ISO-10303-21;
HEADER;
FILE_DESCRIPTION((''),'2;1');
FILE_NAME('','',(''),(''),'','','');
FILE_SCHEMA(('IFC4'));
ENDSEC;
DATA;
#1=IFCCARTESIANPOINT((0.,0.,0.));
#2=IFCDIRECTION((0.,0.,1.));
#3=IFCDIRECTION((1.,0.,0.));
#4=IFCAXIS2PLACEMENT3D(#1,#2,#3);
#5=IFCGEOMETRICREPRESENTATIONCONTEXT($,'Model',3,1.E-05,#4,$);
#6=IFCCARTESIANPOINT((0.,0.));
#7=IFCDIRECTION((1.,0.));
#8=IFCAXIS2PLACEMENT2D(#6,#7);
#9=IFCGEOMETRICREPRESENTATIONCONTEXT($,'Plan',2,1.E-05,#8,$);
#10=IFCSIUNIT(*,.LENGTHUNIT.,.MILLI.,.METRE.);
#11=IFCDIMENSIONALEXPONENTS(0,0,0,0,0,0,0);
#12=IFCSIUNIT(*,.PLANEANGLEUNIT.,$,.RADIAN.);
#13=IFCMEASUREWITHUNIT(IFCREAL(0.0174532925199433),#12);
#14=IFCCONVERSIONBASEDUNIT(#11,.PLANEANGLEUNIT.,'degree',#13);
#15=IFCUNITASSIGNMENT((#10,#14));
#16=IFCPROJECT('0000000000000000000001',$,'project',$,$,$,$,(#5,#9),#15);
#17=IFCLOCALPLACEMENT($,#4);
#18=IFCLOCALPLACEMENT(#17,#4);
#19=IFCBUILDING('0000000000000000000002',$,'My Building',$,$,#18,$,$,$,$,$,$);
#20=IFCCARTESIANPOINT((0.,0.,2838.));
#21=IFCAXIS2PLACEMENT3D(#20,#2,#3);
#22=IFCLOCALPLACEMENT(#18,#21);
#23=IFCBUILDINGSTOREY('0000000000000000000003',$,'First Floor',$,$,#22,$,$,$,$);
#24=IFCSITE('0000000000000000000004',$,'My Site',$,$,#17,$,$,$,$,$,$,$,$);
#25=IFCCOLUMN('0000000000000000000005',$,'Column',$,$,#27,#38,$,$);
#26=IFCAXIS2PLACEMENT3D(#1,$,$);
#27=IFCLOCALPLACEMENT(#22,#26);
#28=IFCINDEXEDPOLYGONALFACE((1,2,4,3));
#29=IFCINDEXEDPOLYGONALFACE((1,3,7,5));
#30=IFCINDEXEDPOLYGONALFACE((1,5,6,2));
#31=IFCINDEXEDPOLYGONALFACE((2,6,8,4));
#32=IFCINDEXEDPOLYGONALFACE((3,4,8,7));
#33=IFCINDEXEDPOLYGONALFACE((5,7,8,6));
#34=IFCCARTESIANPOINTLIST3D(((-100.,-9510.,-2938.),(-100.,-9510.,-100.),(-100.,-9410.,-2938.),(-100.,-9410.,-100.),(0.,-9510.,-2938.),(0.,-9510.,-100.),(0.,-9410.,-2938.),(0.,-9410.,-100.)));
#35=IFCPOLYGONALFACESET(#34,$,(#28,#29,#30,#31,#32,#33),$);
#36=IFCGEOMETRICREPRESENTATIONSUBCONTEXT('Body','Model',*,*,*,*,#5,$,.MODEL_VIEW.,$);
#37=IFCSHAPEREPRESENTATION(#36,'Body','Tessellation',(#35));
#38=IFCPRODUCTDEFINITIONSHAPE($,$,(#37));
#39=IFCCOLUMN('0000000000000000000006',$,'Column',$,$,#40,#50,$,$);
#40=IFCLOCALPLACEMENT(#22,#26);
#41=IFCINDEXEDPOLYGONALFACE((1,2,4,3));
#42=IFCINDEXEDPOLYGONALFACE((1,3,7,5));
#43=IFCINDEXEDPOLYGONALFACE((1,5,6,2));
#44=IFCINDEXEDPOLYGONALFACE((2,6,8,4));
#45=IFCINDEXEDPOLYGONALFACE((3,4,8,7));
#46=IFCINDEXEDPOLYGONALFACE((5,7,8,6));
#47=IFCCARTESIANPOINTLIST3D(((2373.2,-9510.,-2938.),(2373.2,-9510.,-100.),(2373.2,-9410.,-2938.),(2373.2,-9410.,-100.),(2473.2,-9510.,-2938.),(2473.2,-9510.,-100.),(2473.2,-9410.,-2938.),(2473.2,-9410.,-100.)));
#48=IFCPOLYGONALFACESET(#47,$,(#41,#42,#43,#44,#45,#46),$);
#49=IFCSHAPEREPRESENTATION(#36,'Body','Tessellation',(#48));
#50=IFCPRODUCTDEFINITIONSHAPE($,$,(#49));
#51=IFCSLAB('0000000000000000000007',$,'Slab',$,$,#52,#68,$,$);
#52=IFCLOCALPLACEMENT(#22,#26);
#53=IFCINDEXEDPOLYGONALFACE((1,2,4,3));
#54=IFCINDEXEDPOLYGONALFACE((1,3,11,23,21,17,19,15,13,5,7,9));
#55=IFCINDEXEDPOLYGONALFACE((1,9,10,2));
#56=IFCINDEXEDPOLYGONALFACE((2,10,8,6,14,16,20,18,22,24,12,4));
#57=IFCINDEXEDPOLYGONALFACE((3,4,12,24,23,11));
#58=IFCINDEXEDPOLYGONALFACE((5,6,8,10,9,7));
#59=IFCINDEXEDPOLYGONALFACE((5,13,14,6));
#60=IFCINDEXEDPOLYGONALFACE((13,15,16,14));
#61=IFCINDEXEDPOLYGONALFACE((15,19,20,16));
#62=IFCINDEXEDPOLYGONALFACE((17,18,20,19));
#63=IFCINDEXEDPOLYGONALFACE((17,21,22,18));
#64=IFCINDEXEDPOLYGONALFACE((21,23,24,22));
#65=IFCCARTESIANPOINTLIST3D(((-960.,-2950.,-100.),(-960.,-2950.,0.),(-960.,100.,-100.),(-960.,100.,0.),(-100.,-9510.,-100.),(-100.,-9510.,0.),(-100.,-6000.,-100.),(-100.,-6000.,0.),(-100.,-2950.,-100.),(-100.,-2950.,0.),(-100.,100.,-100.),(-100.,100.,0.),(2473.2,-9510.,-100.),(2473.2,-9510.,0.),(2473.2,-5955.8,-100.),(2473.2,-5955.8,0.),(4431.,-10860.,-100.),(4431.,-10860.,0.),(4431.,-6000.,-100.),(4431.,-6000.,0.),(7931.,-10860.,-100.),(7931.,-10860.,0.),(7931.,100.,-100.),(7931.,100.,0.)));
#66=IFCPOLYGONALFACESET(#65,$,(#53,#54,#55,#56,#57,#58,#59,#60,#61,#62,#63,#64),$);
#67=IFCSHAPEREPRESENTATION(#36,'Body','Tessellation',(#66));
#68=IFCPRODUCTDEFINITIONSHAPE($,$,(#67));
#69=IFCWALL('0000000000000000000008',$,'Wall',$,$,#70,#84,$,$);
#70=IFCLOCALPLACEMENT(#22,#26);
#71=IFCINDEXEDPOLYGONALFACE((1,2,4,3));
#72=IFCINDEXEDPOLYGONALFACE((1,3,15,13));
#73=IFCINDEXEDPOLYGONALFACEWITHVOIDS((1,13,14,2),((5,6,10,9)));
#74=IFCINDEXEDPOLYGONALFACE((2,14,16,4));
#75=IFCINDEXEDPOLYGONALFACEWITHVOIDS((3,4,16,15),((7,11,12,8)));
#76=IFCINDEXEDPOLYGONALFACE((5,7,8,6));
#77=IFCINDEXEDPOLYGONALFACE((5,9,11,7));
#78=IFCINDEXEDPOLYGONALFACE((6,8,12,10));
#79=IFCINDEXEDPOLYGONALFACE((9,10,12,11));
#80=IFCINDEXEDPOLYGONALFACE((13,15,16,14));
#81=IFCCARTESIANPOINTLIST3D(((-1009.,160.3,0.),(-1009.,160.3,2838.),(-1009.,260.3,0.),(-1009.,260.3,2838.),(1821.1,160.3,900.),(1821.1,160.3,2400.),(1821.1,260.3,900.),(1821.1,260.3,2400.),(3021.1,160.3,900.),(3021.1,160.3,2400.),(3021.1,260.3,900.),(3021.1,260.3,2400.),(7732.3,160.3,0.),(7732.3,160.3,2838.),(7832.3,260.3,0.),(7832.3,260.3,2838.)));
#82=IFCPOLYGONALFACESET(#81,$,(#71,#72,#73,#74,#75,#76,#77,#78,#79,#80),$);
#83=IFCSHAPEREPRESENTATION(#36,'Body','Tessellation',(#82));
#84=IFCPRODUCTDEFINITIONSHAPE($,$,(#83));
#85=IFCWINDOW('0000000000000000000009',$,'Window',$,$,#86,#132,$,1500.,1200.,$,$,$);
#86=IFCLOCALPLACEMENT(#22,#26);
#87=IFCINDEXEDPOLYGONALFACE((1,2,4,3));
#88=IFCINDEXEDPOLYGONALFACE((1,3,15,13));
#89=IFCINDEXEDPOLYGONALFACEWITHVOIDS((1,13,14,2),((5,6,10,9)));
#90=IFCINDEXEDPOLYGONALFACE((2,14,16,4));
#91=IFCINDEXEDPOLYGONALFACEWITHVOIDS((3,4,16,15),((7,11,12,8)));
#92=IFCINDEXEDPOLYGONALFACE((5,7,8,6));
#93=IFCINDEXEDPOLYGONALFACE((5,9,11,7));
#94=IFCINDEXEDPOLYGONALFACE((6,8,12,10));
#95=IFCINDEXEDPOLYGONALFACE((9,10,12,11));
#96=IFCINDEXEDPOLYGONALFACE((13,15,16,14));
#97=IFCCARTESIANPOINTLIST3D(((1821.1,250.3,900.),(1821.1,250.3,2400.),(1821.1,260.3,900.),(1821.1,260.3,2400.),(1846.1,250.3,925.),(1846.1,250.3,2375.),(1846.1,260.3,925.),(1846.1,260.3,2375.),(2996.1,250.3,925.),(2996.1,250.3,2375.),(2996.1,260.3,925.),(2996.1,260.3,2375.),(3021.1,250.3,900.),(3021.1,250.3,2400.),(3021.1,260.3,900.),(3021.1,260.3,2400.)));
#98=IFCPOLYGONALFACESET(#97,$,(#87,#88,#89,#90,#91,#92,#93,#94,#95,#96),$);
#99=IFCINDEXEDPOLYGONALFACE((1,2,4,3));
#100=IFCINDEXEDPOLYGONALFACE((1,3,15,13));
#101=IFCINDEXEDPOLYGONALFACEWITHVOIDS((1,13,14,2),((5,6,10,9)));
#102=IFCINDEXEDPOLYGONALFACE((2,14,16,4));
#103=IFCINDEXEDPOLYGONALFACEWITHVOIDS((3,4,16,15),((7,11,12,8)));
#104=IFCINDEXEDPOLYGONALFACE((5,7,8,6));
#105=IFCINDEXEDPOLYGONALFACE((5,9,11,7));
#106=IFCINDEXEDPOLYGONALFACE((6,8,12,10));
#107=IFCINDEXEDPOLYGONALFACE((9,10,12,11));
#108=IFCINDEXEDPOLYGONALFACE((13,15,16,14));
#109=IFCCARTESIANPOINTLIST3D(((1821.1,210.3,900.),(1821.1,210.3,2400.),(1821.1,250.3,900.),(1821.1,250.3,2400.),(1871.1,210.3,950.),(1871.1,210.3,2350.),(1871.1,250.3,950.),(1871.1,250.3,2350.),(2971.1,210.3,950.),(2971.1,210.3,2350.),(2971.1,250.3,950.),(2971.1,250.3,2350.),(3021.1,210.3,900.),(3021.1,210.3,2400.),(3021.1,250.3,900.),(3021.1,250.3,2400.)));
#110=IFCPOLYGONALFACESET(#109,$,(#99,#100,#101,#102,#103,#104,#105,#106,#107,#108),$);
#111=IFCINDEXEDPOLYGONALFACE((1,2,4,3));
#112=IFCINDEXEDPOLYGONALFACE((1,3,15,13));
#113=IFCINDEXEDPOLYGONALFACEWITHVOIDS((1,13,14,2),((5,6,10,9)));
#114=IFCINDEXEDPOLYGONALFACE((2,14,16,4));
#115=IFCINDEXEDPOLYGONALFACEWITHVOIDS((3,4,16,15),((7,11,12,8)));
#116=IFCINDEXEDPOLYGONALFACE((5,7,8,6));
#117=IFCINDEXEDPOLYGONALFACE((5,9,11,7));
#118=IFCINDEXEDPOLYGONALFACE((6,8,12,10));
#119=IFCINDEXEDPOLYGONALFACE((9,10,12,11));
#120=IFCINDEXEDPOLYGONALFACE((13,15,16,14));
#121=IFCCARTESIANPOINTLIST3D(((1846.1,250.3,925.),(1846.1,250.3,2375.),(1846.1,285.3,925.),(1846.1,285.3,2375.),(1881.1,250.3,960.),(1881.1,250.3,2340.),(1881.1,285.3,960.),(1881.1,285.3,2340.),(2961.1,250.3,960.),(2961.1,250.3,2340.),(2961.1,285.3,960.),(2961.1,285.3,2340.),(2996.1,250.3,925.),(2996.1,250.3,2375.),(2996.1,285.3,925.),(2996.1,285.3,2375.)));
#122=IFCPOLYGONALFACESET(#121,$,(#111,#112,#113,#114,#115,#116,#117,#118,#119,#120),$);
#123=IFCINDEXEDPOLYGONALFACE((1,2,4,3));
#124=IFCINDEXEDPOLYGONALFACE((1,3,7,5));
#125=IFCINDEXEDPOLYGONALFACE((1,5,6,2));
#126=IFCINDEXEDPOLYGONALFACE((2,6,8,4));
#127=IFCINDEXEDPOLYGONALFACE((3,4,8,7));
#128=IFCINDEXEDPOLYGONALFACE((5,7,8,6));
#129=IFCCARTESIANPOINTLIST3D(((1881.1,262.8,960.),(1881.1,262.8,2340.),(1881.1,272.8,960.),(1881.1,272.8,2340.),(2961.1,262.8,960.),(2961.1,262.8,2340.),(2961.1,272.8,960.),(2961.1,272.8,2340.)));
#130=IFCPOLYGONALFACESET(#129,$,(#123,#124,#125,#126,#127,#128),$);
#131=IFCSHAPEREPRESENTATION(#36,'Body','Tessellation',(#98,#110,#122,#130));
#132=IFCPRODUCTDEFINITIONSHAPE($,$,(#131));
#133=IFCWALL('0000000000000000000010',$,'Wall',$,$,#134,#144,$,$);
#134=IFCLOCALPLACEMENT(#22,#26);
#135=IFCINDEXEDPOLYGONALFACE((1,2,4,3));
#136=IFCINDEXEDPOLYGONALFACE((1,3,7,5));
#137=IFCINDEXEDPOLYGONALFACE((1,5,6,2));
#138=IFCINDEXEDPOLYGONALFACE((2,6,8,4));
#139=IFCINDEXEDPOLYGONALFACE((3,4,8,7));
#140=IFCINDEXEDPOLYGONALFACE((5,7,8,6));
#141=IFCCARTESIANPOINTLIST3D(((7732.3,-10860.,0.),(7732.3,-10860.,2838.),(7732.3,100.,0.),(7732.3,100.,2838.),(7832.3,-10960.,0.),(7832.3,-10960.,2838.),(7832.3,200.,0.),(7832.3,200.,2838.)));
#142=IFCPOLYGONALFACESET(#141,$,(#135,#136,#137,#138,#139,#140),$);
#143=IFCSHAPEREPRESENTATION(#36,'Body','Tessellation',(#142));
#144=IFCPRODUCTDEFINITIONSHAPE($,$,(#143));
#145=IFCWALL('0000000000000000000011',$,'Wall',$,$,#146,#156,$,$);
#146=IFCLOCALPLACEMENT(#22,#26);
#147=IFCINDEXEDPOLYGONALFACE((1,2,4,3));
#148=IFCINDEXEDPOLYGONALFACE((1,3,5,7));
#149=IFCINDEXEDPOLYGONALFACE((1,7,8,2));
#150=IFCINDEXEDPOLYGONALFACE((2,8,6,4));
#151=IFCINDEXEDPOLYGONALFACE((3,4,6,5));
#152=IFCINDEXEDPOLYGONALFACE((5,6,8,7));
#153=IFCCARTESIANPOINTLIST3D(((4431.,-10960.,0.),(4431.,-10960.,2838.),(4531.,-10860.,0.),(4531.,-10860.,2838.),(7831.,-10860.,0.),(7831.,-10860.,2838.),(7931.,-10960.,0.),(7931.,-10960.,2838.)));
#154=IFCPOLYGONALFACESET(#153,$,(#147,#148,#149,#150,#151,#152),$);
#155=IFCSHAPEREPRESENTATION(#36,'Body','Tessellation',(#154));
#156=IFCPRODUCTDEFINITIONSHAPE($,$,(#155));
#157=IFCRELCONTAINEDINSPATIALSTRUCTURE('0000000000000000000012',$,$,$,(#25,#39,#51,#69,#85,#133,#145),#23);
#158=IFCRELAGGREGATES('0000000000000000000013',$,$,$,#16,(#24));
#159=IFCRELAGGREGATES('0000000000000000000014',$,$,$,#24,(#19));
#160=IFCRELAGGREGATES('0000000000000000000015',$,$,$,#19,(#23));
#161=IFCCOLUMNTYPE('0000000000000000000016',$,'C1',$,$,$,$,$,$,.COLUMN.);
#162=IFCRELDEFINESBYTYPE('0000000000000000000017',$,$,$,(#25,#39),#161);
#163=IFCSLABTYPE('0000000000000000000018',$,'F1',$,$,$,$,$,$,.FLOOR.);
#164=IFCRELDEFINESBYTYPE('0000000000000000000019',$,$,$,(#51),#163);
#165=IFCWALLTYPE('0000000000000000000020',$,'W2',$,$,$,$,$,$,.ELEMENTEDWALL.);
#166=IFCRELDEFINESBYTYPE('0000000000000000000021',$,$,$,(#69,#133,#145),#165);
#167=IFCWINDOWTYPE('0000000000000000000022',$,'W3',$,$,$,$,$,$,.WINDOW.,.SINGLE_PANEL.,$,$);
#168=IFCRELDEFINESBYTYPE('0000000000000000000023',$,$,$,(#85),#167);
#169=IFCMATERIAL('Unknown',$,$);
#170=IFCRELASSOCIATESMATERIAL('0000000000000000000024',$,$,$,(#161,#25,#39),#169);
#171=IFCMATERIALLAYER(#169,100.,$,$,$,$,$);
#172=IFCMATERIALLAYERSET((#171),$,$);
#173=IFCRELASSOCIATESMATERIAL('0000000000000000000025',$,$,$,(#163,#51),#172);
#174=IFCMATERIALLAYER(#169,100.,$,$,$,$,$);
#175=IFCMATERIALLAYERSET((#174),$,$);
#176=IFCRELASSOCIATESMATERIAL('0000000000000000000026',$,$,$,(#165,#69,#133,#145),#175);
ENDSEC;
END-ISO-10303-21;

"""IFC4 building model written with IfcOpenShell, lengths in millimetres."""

from ifc_helpers import new_model, entity, si_unit, converted_unit, frame, origin_with_axes, origin_2d_with_axis, place, context, subcontext, project, spatial, line, indexed_curve, rectangle, outline, extrude, clip, halfspace, shape, source, transform, mapped, material, layer, layer_set, layer_usage, material_profile, profile_set, profile_usage, type_object, type_shapes, element, fill, save


model = new_model("IFC4")

# Units and contexts
model_context = context("Model", 3, precision=1e-05, world=origin_with_axes())
plan_context = context("Plan", 2, precision=1e-05, world=origin_2d_with_axis())
body_context_1 = subcontext(model_context, "Body", "Model", "MODEL_VIEW")
body_context_2 = subcontext(plan_context, "Body", "Plan", "PLAN_VIEW")
ifc_project = project(units=[si_unit("LENGTHUNIT", "METRE", prefix="MILLI"), converted_unit("PLANEANGLEUNIT", "degree", entity("IfcReal", 0.0174532925199433), si_unit("PLANEANGLEUNIT", "RADIAN"), dimensions=[0, 0, 0, 0, 0, 0, 0])], contexts=[model_context, plan_context])

# Site, building, storey
site_placement = place(None, origin_with_axes())
site = spatial("IfcSite", under=ifc_project, at=site_placement, Name="My Site")
building_placement = place(site_placement, origin_with_axes())
building = spatial("IfcBuilding", under=site, at=building_placement, Name="My Building")
storey_placement = place(building_placement, frame((0.0, 0.0, 2838.0), z_axis=(0.0, 0.0, 1.0), x_axis=(1.0, 0.0, 0.0)))
storey = spatial("IfcBuildingStorey", under=building, at=storey_placement, Name="First Floor")

# Columns
ifc_material = material(Name="Unknown")
ifc_material_profile = material_profile(ifc_material, rectangle(XDim=100.0, YDim=100.0))
ifc_profile_set = profile_set([ifc_material_profile])
ifc_profile_usage_1 = profile_usage(ifc_profile_set, cardinal=5)
column_type = type_object("IfcColumnType", Name="C1", PredefinedType="COLUMN", material=ifc_profile_set)
column_1_placement = place(storey_placement, frame((-50.0, -9460.0, -2938.0), z_axis=(0.0, 0.0, 1.0), x_axis=(1.0, 0.0, 0.0)))
element("IfcColumn", 1, at=column_1_placement, inside=storey, type_object=column_type, material=ifc_profile_usage_1, Name="Column", context=body_context_1, shape_type="SweptSolid", body=[
    extrude(rectangle(XDim=100.0, YDim=100.0), origin_with_axes(), (0.0, 0.0, 1.0), 2838.0),
])
ifc_profile_usage_2 = profile_usage(ifc_profile_set, cardinal=5)
column_2_placement = place(storey_placement, frame((2423.2, -9460.0, -2938.0), z_axis=(0.0, 0.0, 1.0), x_axis=(1.0, 0.0, 0.0)))
element("IfcColumn", 2, at=column_2_placement, inside=storey, type_object=column_type, material=ifc_profile_usage_2, Name="Column", context=body_context_1, shape_type="SweptSolid", body=[
    extrude(rectangle(XDim=100.0, YDim=100.0), origin_with_axes(), (0.0, 0.0, 1.0), 2838.0),
])

# Slab
ifc_layer_1 = layer(ifc_material, 100.0)
ifc_layer_set_1 = layer_set([ifc_layer_1])
ifc_layer_usage_1 = layer_usage(ifc_layer_set_1, "AXIS3", "POSITIVE", -100.0)
slab_type = type_object("IfcSlabType", Name="F1", PredefinedType="FLOOR", material=ifc_layer_set_1)
slab_placement = place(storey_placement, frame((2473.2, -9510.0, 0.0), z_axis=(0.0, 0.0, 1.0), x_axis=(1.0, 0.0, 0.0)))
element("IfcSlab", 3, at=slab_placement, inside=storey, type_object=slab_type, material=ifc_layer_usage_1, Name="Slab", context=body_context_1, shape_type="SweptSolid", body=[
    extrude(outline(indexed_curve([(0.0, 0.0), (-2573.2, 0.0), (-2573.2, 3510.0), (-2573.2, 6560.0), (-3433.2, 6560.0), (-3433.2, 9610.0), (-2573.2, 9610.0), (5457.8, 9610.0), (5457.8, -1350.0), (1957.8, -1350.0), (1957.8, 3510.0), (0.0, 3554.2), (0.0, 0.0)])), frame((0.0, 0.0, -100.0), z_axis=(0.0, 0.0, 1.0), x_axis=(1.0, 0.0, 0.0)), (0.0, 0.0, 1.0), 100.0),
])

# Wall, opening, window
ifc_layer_2 = layer(ifc_material, 100.0)
ifc_layer_set_2 = layer_set([ifc_layer_2])
ifc_layer_usage_2 = layer_usage(ifc_layer_set_2, "AXIS2", "POSITIVE", 0.0)
wall_type = type_object("IfcWallType", Name="W2", PredefinedType="ELEMENTEDWALL", material=ifc_layer_set_2)
wall_1_placement = place(storey_placement, frame((-1009.0, 160.3, 0.0), z_axis=(0.0, 0.0, 1.0), x_axis=(1.0, 0.0, 0.0)))
wall_1 = element("IfcWall", 4, at=wall_1_placement, inside=storey, type_object=wall_type, material=ifc_layer_usage_2, Name="Wall", context=body_context_1, shape_type="Clipping", body=[
    clip(extrude(outline(indexed_curve([(0.0, 0.0), (0.0, 100.0), (8841.3, 100.0), (8841.3, 0.0), (0.0, 0.0)], self_intersect=False)), origin_with_axes(), (0.0, 0.0, 1.0), 2838.0), halfspace(frame((8741.3, 0.0, -2838.0), z_axis=(0.707107, -0.707106, 0.0), x_axis=(-0.707106, -0.707107, 0.0)), False)),
])
shared_shape_1 = source(origin_with_axes(), body_context_1, "Body", "SolidModel", [
    extrude(outline(indexed_curve([(0.0, 0.0), (1200.0, 0.0), (1200.0, 1500.0), (0.0, 1500.0)], segments=[line(1, 2, 3, 4, 1)])), frame((0.0, -600.0, 0.0), z_axis=(0.0, -1.0, 0.0), x_axis=(1.0, 0.0, 0.0)), (0.0, 0.0, -1.0), 1200.0),
])
opening_1_placement = place(wall_1_placement, frame((2830.1, 0.0, 900.0), z_axis=(0.0, 0.0, 1.0), x_axis=(1.0, 0.0, 0.0)))
opening_1 = element("IfcOpeningElement", 5, at=opening_1_placement, cuts=wall_1, PredefinedType="OPENING", context=body_context_1, shape_type="MappedRepresentation", body=[
    mapped(shared_shape_1, transform((0.0, 0.0, 0.0), x_axis=(1.0, 0.0, 0.0), y_axis=(0.0, 1.0, 0.0), z_axis=(0.0, 0.0, 1.0), scale=1.0)),
])
window_type = type_object("IfcWindowType", Name="W3", PartitioningType="SINGLE_PANEL", PredefinedType="WINDOW")
shared_shape_2 = source(origin_with_axes(), body_context_1, "Body", "SolidModel", [
    extrude(outline(indexed_curve([(0.0, 0.0), (1200.0, 0.0), (1200.0, 1500.0), (0.0, 1500.0)], segments=[line(1, 2, 3, 4, 1)]), holes=[indexed_curve([(25.0, 25.0), (1175.0, 25.0), (1175.0, 1475.0), (25.0, 1475.0)], segments=[line(1, 2, 3, 4, 1)])]), frame((0.0, 90.0, 0.0), z_axis=(0.0, -1.0, 0.0), x_axis=(1.0, 0.0, 0.0)), (0.0, 0.0, -1.0), 10.0),
    extrude(outline(indexed_curve([(0.0, 0.0), (1200.0, 0.0), (1200.0, 1500.0), (0.0, 1500.0)], segments=[line(1, 2, 3, 4, 1)]), holes=[indexed_curve([(50.0, 50.0), (1150.0, 50.0), (1150.0, 1450.0), (50.0, 1450.0)], segments=[line(1, 2, 3, 4, 1)])]), frame((0.0, 50.0, 0.0), z_axis=(0.0, -1.0, 0.0), x_axis=(1.0, 0.0, 0.0)), (0.0, 0.0, -1.0), 40.0),
    extrude(outline(indexed_curve([(0.0, 0.0), (1150.0, 0.0), (1150.0, 1450.0), (0.0, 1450.0)], segments=[line(1, 2, 3, 4, 1)]), holes=[indexed_curve([(35.0, 35.0), (1115.0, 35.0), (1115.0, 1415.0), (35.0, 1415.0)], segments=[line(1, 2, 3, 4, 1)])]), frame((25.0, 90.0, 25.0), z_axis=(0.0, -1.0, 0.0), x_axis=(1.0, 0.0, 0.0)), (0.0, 0.0, -1.0), 35.0),
    extrude(outline(indexed_curve([(35.0, 35.0), (1115.0, 35.0), (1115.0, 1415.0), (35.0, 1415.0)], segments=[line(1, 2, 3, 4, 1)])), frame((25.0, 102.5, 25.0), z_axis=(0.0, -1.0, 0.0), x_axis=(1.0, 0.0, 0.0)), (0.0, 0.0, -1.0), 10.0),
])
shared_shape_3 = source(origin_with_axes(), body_context_2, "Body", "Curve2D", [
    entity("IfcIndexedPolyCurve", entity("IfcCartesianPointList2D", [[50.0, 50.0], [1150.0, 50.0]])),
    entity("IfcIndexedPolyCurve", entity("IfcCartesianPointList2D", [[0.0, 100.0], [25.0, 100.0], [25.0, 90.0], [50.0, 90.0], [50.0, 50.0], [0.0, 50.0]]), [entity("IfcLineIndex", [1, 2, 3, 4, 5, 6, 1])]),
    entity("IfcIndexedPolyCurve", entity("IfcCartesianPointList2D", [[1200.0, 100.0], [1175.0, 100.0], [1175.0, 90.0], [1150.0, 90.0], [1150.0, 50.0], [1200.0, 50.0]]), [entity("IfcLineIndex", [1, 2, 3, 4, 5, 6, 1])]),
    entity("IfcIndexedPolyCurve", entity("IfcCartesianPointList2D", [[25.0, 90.0], [60.0, 90.0], [60.0, 125.0], [25.0, 125.0]]), [entity("IfcLineIndex", [1, 2, 3, 4, 1])]),
    entity("IfcIndexedPolyCurve", entity("IfcCartesianPointList2D", [[1175.0, 90.0], [1140.0, 90.0], [1140.0, 125.0], [1175.0, 125.0]]), [entity("IfcLineIndex", [1, 2, 3, 4, 1])]),
    entity("IfcIndexedPolyCurve", entity("IfcCartesianPointList2D", [[60.0, 90.0], [1140.0, 90.0]])),
    entity("IfcIndexedPolyCurve", entity("IfcCartesianPointList2D", [[60.0, 125.0], [1140.0, 125.0]])),
    entity("IfcIndexedPolyCurve", entity("IfcCartesianPointList2D", [[60.0, 107.5], [1140.0, 107.5]])),
])
type_shapes(window_type, [shared_shape_2, shared_shape_3])
window_placement = place(opening_1_placement, origin_with_axes())
window = element("IfcWindow", 6, at=window_placement, inside=storey, type_object=window_type, Name="Window", OverallHeight=1500.0, OverallWidth=1200.0, shapes=[
    shape(body_context_1, "Body", "MappedRepresentation", [mapped(shared_shape_2, transform((0.0, 0.0, 0.0), x_axis=(1.0, 0.0, 0.0), y_axis=(0.0, 1.0, 0.0), z_axis=(0.0, 0.0, 1.0), scale=1.0))]),
    shape(body_context_2, "Body", "MappedRepresentation", [mapped(shared_shape_3, transform((0.0, 0.0, 0.0), x_axis=(1.0, 0.0, 0.0), y_axis=(0.0, 1.0, 0.0), z_axis=(0.0, 0.0, 1.0), scale=1.0))]),
])
fill(opening_1, window)

# Walls
ifc_layer_usage_3 = layer_usage(ifc_layer_set_2, "AXIS2", "POSITIVE", 0.0)
wall_2_placement = place(storey_placement, frame((7832.3, -10960.0, 0.0), z_axis=(0.0, 0.0, 1.0), x_axis=(0.0, 1.0, 0.0)))
element("IfcWall", 7, at=wall_2_placement, inside=storey, type_object=wall_type, material=ifc_layer_usage_3, Name="Wall", context=body_context_1, shape_type="Clipping", body=[
    clip(clip(extrude(outline(indexed_curve([(0.0, 0.0), (0.0, 100.0), (11160.0, 100.0), (11160.0, 0.0), (0.0, 0.0)], self_intersect=False)), origin_with_axes(), (0.0, 0.0, 1.0), 2838.0), halfspace(frame((0.0, 0.0, -2838.0), z_axis=(-0.707105, 0.707109, 0.0), x_axis=(0.707109, 0.707105, 0.0)), False)), halfspace(frame((11160.0, 0.0, -2838.0), z_axis=(0.707107, 0.707107, 0.0), x_axis=(0.707107, -0.707107, 0.0)), False)),
])
ifc_layer_usage_4 = layer_usage(ifc_layer_set_2, "AXIS2", "POSITIVE", 0.0)
wall_3_placement = place(storey_placement, frame((7931.0, -10860.0, 0.0), z_axis=(0.0, 0.0, 1.0), x_axis=(-1.0, 0.0, 0.0)))
element("IfcWall", 8, at=wall_3_placement, inside=storey, type_object=wall_type, material=ifc_layer_usage_4, Name="Wall", context=body_context_1, shape_type="Clipping", body=[
    clip(clip(extrude(outline(indexed_curve([(0.0, 0.0), (0.0, 100.0), (3500.0, 100.0), (3500.0, 0.0), (0.0, 0.0)], self_intersect=False)), origin_with_axes(), (0.0, 0.0, 1.0), 2838.0), halfspace(frame((3400.0, 0.0, -2838.0), z_axis=(0.707109, -0.707105, 0.0), x_axis=(-0.707105, -0.707109, 0.0)), False)), halfspace(frame((100.0, 0.0, -2838.0), z_axis=(-0.707108, -0.707105, 0.0), x_axis=(-0.707105, 0.707108, 0.0)), False)),
])

save(model, "model.ifc")
